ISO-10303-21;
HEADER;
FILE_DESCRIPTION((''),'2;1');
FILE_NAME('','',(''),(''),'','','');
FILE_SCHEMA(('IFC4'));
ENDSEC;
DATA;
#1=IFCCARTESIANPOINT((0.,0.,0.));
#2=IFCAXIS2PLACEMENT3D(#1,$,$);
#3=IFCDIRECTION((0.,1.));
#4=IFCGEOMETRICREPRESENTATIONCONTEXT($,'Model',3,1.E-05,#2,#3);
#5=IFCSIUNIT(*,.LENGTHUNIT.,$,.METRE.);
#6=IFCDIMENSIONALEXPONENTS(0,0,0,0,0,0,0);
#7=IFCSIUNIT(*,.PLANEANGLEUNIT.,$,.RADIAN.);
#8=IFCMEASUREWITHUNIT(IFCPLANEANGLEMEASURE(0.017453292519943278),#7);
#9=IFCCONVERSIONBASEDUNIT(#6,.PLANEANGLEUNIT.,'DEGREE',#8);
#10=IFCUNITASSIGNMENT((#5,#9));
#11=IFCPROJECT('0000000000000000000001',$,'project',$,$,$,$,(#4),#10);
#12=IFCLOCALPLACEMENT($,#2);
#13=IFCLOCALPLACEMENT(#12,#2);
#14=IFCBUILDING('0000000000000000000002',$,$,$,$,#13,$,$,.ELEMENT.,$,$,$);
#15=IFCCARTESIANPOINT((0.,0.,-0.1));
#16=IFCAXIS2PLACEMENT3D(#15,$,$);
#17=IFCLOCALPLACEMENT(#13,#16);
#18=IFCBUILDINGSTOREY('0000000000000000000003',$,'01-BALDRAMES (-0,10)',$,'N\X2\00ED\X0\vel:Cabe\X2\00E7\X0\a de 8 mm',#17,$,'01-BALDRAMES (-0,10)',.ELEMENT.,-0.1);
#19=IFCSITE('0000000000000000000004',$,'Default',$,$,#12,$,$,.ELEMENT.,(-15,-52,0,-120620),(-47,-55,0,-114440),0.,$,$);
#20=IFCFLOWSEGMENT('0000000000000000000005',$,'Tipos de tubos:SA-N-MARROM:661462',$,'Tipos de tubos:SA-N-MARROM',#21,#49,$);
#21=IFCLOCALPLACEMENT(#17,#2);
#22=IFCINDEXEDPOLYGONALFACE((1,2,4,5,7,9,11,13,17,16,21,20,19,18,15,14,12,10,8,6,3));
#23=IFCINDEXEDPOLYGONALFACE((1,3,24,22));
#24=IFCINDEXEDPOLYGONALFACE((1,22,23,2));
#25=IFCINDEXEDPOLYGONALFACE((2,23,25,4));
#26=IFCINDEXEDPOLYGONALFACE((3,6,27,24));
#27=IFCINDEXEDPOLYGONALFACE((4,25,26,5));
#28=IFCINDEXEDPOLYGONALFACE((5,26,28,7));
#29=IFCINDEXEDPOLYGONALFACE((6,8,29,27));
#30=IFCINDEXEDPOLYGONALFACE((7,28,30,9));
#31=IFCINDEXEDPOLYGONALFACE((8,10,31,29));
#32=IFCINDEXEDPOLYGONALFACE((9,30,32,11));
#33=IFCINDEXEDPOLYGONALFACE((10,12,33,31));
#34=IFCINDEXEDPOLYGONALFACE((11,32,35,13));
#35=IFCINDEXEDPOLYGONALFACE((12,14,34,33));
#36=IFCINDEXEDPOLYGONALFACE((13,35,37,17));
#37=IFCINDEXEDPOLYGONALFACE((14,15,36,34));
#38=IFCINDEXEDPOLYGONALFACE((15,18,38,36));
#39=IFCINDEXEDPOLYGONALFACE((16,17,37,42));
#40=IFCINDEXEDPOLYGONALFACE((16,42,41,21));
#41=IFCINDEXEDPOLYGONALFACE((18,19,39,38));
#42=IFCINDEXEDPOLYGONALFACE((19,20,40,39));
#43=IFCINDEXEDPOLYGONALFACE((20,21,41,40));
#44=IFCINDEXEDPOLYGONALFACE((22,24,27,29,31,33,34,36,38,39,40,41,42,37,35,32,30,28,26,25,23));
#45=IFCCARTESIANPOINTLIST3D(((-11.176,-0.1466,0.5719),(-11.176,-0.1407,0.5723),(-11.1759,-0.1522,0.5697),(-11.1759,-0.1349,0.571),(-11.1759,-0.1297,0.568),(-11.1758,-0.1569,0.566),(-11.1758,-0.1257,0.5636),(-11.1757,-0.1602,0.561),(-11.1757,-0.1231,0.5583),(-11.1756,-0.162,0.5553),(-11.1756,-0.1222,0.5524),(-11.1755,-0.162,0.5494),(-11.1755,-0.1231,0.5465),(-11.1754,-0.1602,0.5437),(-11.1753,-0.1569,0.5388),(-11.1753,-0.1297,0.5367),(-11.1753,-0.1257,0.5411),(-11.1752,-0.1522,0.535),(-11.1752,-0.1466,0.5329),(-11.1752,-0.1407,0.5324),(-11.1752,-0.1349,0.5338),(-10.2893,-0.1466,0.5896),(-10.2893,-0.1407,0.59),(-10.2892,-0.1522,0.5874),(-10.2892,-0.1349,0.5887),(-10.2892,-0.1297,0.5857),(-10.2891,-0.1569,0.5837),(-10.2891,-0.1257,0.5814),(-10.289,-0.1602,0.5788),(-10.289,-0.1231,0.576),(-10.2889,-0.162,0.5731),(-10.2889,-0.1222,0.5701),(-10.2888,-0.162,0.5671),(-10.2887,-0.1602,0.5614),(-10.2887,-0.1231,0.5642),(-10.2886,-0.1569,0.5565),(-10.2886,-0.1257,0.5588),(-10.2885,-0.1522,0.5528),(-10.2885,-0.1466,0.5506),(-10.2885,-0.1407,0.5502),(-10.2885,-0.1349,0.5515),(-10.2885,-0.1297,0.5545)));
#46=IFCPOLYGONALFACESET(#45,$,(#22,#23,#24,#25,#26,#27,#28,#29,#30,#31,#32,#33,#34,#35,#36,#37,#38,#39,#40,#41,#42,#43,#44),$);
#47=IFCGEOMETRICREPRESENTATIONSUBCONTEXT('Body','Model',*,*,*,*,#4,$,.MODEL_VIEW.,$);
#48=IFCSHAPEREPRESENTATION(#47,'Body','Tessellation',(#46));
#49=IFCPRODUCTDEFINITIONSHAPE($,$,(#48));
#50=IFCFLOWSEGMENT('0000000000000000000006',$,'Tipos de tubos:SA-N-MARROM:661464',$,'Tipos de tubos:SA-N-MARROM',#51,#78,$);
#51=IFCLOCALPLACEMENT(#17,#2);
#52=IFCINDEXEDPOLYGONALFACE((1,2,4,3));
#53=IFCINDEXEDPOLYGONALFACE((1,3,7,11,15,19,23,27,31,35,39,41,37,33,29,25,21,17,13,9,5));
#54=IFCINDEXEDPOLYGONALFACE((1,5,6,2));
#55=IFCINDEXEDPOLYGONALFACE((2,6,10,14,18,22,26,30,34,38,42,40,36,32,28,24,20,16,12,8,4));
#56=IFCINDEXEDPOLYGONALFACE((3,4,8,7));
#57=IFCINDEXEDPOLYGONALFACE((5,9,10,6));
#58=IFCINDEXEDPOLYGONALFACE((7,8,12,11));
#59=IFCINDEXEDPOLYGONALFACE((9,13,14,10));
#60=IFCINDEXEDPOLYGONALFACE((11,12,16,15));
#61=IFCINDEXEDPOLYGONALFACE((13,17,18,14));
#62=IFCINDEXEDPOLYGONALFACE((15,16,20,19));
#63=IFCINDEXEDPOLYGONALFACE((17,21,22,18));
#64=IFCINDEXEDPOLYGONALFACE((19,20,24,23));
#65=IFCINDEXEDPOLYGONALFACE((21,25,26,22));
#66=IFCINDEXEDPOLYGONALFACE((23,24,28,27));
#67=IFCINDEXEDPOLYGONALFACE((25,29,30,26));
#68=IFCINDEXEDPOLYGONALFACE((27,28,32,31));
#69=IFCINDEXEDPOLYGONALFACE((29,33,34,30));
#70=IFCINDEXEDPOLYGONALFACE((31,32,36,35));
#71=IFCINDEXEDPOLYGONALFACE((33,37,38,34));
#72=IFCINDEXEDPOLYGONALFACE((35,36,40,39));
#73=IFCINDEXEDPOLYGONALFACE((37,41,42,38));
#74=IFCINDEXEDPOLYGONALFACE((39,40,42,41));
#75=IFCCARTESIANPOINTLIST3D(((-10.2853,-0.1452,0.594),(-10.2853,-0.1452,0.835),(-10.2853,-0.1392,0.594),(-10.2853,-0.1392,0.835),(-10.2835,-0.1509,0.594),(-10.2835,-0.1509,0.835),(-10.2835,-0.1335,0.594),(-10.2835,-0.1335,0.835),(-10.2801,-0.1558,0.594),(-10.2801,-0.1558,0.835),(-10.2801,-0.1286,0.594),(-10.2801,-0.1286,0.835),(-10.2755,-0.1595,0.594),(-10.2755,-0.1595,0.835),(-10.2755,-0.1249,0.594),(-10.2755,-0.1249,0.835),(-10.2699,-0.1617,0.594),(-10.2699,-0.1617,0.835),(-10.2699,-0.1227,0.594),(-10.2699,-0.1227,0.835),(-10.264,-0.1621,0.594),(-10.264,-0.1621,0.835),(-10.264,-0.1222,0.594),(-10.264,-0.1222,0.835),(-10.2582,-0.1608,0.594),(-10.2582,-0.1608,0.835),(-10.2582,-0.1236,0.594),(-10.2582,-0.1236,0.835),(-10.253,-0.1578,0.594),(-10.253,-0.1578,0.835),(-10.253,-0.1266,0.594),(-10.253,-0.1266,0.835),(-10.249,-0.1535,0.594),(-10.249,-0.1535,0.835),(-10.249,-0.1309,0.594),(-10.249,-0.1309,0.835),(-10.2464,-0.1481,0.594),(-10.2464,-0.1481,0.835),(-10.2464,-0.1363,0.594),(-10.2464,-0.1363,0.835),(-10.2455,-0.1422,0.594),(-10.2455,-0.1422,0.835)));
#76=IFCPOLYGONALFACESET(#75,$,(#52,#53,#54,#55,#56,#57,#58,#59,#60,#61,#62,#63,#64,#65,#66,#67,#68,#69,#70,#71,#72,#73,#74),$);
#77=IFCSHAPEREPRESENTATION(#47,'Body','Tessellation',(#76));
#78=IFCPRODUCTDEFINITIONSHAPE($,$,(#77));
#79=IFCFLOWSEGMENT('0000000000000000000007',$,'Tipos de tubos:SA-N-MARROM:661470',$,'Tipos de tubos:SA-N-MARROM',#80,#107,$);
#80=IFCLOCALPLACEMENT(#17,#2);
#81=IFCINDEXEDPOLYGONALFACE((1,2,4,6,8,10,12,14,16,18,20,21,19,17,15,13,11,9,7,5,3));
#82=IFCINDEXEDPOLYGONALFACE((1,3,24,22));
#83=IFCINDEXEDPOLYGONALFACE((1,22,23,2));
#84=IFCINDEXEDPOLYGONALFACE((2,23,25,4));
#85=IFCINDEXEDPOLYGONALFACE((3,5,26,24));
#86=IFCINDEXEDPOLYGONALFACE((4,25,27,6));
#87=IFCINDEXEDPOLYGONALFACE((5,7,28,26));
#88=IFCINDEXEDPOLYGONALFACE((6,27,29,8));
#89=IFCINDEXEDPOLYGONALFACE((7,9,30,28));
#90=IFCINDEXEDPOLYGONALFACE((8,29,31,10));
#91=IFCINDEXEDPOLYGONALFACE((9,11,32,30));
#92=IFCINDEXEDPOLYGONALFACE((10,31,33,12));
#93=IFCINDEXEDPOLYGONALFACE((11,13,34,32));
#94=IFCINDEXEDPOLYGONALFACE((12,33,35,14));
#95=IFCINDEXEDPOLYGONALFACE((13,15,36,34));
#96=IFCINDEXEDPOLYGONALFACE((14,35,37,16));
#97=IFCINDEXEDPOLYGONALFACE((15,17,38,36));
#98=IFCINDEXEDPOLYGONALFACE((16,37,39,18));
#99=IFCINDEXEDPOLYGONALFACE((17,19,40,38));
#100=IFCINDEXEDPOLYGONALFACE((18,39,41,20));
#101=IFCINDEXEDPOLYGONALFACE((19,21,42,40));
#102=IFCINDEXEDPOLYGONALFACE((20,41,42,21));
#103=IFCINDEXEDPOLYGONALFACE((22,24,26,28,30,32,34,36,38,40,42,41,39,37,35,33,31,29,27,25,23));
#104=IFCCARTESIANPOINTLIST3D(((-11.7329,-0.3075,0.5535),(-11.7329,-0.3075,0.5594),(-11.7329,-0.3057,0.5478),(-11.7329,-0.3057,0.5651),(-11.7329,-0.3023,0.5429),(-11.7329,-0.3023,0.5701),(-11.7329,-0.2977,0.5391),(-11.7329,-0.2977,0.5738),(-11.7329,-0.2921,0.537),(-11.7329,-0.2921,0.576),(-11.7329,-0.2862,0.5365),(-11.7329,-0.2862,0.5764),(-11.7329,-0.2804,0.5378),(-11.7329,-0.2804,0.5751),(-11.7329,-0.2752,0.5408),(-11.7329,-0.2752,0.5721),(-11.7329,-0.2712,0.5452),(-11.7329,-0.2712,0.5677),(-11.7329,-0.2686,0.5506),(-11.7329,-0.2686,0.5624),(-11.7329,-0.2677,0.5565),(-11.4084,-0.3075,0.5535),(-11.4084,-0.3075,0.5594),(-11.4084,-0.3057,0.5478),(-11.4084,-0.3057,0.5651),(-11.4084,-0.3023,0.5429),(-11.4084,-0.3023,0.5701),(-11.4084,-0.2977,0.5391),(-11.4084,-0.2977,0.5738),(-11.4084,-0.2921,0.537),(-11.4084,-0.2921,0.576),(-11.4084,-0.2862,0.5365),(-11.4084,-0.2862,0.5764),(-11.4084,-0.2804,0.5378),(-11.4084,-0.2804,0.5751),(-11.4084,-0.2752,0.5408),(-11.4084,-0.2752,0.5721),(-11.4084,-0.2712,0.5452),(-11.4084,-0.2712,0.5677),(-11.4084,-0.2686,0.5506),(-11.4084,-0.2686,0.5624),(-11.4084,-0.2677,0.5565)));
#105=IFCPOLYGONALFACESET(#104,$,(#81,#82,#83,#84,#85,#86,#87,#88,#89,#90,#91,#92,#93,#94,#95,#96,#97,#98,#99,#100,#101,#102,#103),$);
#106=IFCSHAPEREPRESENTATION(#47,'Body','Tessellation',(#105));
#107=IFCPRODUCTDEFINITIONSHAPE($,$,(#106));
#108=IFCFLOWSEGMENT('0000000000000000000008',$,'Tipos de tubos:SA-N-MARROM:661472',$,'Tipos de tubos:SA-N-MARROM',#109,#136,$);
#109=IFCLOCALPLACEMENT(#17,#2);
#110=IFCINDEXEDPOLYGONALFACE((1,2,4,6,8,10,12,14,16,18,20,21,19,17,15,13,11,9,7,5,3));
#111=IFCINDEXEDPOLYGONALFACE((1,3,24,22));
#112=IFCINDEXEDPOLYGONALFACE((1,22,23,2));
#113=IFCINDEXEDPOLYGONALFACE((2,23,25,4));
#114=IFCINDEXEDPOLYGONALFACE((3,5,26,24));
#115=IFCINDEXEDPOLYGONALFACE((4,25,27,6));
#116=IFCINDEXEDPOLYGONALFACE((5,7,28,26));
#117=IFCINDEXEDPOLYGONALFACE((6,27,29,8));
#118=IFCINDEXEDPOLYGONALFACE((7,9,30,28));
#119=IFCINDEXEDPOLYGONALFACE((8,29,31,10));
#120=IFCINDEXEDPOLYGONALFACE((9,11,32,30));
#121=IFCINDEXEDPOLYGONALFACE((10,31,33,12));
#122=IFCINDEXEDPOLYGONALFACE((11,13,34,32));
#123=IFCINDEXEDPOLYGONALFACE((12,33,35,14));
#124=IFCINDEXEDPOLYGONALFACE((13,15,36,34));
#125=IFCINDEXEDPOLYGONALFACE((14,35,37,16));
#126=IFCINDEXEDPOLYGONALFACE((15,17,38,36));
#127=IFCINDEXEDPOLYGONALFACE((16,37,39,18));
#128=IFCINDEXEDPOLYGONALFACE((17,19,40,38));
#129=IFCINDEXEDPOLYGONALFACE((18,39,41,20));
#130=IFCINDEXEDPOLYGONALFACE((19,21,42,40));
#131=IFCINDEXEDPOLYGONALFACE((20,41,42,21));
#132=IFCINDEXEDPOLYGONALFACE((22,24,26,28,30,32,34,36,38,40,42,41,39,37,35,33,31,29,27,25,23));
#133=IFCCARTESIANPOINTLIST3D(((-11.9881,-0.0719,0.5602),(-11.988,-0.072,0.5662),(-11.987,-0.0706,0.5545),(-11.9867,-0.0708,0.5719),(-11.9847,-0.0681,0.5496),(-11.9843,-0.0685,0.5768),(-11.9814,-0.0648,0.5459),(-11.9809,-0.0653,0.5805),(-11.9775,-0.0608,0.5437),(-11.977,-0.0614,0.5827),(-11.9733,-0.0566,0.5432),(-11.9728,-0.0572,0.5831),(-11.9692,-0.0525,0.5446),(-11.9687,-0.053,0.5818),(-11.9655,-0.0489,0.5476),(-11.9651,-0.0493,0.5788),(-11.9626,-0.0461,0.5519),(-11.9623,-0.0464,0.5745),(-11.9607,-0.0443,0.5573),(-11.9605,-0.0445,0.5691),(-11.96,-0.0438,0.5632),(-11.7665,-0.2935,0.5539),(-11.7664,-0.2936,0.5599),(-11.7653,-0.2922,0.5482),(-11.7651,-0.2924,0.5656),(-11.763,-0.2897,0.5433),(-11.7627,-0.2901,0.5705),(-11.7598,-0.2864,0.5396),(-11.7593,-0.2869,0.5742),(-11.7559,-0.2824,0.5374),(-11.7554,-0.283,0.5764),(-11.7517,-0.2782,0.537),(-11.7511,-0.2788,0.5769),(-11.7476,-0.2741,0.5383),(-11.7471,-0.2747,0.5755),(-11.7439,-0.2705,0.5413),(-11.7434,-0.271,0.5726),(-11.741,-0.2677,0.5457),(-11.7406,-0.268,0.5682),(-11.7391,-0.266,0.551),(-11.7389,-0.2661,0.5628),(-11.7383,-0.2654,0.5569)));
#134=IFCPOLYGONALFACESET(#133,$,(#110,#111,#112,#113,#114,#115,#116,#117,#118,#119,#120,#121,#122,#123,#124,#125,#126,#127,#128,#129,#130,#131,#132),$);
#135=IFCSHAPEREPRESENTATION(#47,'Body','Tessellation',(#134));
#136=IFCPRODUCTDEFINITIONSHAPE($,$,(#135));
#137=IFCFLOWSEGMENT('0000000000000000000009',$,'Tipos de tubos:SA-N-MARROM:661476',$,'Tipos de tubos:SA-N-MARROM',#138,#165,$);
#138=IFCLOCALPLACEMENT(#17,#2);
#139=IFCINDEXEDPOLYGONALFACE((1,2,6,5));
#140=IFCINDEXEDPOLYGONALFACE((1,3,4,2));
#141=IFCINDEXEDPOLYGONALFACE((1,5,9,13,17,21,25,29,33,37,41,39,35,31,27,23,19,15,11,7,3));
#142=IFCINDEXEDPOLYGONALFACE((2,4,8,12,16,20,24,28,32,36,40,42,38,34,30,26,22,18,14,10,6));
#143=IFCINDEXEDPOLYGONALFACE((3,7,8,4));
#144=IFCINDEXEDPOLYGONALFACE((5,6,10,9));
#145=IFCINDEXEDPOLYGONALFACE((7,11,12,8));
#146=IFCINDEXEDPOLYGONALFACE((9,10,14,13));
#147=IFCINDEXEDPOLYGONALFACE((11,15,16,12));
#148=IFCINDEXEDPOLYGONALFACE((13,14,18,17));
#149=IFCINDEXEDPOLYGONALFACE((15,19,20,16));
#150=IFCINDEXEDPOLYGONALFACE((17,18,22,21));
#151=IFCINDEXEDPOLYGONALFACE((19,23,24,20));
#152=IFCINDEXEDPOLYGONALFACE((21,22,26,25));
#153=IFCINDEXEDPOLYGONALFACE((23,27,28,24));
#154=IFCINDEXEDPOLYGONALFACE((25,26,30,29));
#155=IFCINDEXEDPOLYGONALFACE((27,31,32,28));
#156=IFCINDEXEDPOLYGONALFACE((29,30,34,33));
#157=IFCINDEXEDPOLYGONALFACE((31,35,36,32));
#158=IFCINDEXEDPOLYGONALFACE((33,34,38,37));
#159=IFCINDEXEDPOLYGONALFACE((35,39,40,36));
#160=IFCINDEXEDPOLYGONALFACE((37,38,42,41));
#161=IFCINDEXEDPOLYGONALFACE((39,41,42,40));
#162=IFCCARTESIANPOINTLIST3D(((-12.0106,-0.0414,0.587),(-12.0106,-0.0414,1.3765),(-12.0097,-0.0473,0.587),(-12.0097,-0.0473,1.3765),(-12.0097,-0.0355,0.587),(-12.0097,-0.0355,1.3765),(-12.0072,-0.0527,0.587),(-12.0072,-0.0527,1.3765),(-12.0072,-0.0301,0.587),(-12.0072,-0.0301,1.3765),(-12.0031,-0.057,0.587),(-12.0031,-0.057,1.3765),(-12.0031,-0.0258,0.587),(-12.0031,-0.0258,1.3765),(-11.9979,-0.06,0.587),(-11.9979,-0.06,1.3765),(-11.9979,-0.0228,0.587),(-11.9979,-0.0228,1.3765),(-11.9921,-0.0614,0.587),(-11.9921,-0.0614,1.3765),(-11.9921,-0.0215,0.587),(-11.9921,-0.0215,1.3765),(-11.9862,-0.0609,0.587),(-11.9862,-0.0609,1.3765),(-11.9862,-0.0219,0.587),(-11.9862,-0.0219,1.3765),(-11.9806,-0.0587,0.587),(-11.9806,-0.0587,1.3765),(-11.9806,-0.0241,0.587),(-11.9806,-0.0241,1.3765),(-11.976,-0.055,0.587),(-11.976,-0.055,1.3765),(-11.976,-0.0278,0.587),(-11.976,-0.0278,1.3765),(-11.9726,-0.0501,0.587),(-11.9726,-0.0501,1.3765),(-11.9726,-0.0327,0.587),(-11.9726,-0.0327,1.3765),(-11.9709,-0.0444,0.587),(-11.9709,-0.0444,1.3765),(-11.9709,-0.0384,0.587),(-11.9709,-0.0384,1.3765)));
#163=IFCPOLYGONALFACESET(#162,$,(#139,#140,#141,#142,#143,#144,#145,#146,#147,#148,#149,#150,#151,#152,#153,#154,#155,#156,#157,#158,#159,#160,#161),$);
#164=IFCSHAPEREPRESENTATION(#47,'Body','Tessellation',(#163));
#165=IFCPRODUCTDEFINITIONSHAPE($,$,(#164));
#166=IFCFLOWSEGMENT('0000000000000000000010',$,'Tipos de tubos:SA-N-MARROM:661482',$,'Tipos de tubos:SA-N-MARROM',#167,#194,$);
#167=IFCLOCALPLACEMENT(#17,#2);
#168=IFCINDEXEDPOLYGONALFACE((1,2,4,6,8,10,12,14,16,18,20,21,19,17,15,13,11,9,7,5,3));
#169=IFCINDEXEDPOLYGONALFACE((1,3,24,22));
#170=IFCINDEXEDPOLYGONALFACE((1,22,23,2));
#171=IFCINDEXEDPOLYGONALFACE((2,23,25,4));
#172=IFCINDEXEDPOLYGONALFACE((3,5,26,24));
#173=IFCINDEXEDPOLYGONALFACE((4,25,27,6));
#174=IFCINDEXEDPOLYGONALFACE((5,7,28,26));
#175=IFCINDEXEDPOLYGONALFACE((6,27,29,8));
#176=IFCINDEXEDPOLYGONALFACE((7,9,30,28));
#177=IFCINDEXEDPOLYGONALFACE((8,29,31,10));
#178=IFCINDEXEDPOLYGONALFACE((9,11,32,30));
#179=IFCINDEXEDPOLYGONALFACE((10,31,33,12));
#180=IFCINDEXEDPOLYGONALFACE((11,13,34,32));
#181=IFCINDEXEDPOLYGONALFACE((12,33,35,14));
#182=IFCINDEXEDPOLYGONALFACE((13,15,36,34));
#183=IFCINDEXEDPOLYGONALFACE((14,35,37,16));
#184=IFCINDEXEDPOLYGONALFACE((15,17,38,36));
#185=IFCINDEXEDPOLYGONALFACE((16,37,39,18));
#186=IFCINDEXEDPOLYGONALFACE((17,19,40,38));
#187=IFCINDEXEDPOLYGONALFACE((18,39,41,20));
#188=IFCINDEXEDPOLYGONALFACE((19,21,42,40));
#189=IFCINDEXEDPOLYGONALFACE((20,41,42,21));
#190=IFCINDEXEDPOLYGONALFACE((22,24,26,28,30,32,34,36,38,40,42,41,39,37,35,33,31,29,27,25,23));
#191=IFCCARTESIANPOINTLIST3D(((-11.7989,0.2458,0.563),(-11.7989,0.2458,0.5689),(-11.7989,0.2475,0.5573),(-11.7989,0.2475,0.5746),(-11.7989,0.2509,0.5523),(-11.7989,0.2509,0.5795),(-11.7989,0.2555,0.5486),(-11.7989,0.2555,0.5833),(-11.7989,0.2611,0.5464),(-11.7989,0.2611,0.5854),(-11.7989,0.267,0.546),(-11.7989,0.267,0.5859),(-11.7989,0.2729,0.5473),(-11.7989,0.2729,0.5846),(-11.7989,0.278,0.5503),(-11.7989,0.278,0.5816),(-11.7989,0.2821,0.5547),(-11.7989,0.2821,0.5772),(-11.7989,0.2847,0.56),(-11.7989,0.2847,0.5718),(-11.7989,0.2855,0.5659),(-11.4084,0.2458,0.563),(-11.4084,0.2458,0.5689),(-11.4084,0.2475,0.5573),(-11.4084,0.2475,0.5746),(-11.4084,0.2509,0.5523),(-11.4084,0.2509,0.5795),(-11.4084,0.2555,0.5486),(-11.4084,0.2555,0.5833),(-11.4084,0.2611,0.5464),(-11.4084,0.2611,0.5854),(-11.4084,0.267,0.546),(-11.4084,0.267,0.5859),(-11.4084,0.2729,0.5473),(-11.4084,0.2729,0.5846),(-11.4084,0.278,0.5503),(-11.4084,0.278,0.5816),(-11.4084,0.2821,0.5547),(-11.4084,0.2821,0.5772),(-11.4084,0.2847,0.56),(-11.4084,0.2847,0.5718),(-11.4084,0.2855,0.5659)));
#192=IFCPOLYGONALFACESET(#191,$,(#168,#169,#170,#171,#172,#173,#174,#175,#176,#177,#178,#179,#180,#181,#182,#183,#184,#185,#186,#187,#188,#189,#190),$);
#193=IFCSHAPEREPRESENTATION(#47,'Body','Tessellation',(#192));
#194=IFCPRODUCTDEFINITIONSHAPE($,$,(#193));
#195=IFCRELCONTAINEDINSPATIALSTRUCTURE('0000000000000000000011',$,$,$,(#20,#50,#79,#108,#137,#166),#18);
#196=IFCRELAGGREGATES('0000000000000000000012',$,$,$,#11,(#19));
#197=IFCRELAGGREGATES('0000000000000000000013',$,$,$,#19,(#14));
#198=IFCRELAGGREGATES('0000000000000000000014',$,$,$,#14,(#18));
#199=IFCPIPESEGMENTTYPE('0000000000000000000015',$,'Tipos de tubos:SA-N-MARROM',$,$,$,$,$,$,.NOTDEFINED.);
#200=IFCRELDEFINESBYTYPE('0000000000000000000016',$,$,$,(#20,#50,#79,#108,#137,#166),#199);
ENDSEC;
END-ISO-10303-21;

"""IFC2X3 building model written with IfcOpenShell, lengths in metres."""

from ifc_helpers import new_model, entity, si_unit, converted_unit, direction, frame, frame_2d, origin, place, context, subcontext, project, spatial, circle, extrude, type_object, element, save


model = new_model("IFC2X3")

# Units and contexts
model_context = context("Model", 3, precision=1e-05, world=origin(), true_north=direction((0.0, 1.0)))
body_context = subcontext(model_context, "Body", "Model", "MODEL_VIEW")
ifc_project = project(units=[si_unit("LENGTHUNIT", "METRE"), converted_unit("PLANEANGLEUNIT", "DEGREE", entity("IfcPlaneAngleMeasure", 0.017453292519943278), si_unit("PLANEANGLEUNIT", "RADIAN"), dimensions=[0, 0, 0, 0, 0, 0, 0])], contexts=[model_context])

# Site, building, storey
site_placement = place(None, origin())
site = spatial("IfcSite", under=ifc_project, at=site_placement, Name="Default", CompositionType="ELEMENT", RefLatitude=(-15, -52, 0, -120620), RefLongitude=(-47, -55, 0, -114440), RefElevation=0.0)
building_placement = place(site_placement, origin())
building = spatial("IfcBuilding", under=site, at=building_placement, CompositionType="ELEMENT")
storey_placement = place(building_placement, frame((0.0, 0.0, -0.1)))
storey = spatial("IfcBuildingStorey", under=building, at=storey_placement, Name="01-BALDRAMES (-0,10)", ObjectType="Nível:Cabeça de 8 mm", LongName="01-BALDRAMES (-0,10)", CompositionType="ELEMENT", Elevation=-0.1)

# Flow segments
pipe_segment_type_1 = type_object("IfcPipeSegmentType", Name="Tipos de tubos:SA-N-MARROM", PredefinedType="NOTDEFINED")
flow_segment_1_placement = place(storey_placement, origin())
element("IfcFlowSegment", 1, at=flow_segment_1_placement, inside=storey, type_object=pipe_segment_type_1, Name="Tipos de tubos:SA-N-MARROM:661462", ObjectType="Tipos de tubos:SA-N-MARROM", context=body_context, shape_type="SweptSolid", body=[
    extrude(circle(Radius=0.02, at=frame_2d((0.0, 0.0), x_axis=(1.0, 0.0))), frame((-11.1756, -0.1422, 0.5524), z_axis=(0.9998, 0.000001, 0.019996), x_axis=(-0.000001, 1.0, 0.0)), (0.0, 0.0, 1.0), 0.8869),
])
flow_segment_2_placement = place(storey_placement, origin())
element("IfcFlowSegment", 2, at=flow_segment_2_placement, inside=storey, type_object=pipe_segment_type_1, Name="Tipos de tubos:SA-N-MARROM:661464", ObjectType="Tipos de tubos:SA-N-MARROM", context=body_context, shape_type="SweptSolid", body=[
    extrude(circle(Radius=0.02, at=frame_2d((0.0, 0.0), x_axis=(1.0, 0.0))), frame((-10.2655, -0.1422, 0.594)), (0.0, 0.0, 1.0), 0.241),
])
flow_segment_3_placement = place(storey_placement, origin())
element("IfcFlowSegment", 3, at=flow_segment_3_placement, inside=storey, type_object=pipe_segment_type_1, Name="Tipos de tubos:SA-N-MARROM:661470", ObjectType="Tipos de tubos:SA-N-MARROM", context=body_context, shape_type="SweptSolid", body=[
    extrude(circle(Radius=0.02, at=frame_2d((0.0, 0.0), x_axis=(1.0, 0.0))), frame((-11.7329, -0.2877, 0.5565), z_axis=(1.0, 0.000001, 0.0), x_axis=(-0.000001, 1.0, 0.0)), (0.0, 0.0, 1.0), 0.3245),
])
flow_segment_4_placement = place(storey_placement, origin())
element("IfcFlowSegment", 4, at=flow_segment_4_placement, inside=storey, type_object=pipe_segment_type_1, Name="Tipos de tubos:SA-N-MARROM:661472", ObjectType="Tipos de tubos:SA-N-MARROM", context=body_context, shape_type="SweptSolid", body=[
    extrude(circle(Radius=0.02, at=frame_2d((0.0, 0.0), x_axis=(1.0, 0.0))), frame((-11.9741, -0.0579, 0.5632), z_axis=(0.706966, -0.706965, -0.019996), x_axis=(0.707106, 0.707107, 0.0)), (0.0, 0.0, 1.0), 0.3135),
])
flow_segment_5_placement = place(storey_placement, origin())
element("IfcFlowSegment", 5, at=flow_segment_5_placement, inside=storey, type_object=pipe_segment_type_1, Name="Tipos de tubos:SA-N-MARROM:661476", ObjectType="Tipos de tubos:SA-N-MARROM", context=body_context, shape_type="SweptSolid", body=[
    extrude(circle(Radius=0.02, at=frame_2d((0.0, 0.0), x_axis=(1.0, 0.0))), frame((-11.9906, -0.0414, 0.587), z_axis=(0.0, 0.0, 1.0), x_axis=(-1.0, 0.0, 0.0)), (0.0, 0.0, 1.0), 0.7895),
])
flow_segment_6_placement = place(storey_placement, origin())
element("IfcFlowSegment", 6, at=flow_segment_6_placement, inside=storey, type_object=pipe_segment_type_1, Name="Tipos de tubos:SA-N-MARROM:661482", ObjectType="Tipos de tubos:SA-N-MARROM", context=body_context, shape_type="SweptSolid", body=[
    extrude(circle(Radius=0.02, at=frame_2d((0.0, 0.0), x_axis=(1.0, 0.0))), frame((-11.7989, 0.2655, 0.5659), z_axis=(1.0, 0.000001, 0.0), x_axis=(-0.000001, 1.0, 0.0)), (0.0, 0.0, 1.0), 0.3905),
])

save(model, "model.ifc")
